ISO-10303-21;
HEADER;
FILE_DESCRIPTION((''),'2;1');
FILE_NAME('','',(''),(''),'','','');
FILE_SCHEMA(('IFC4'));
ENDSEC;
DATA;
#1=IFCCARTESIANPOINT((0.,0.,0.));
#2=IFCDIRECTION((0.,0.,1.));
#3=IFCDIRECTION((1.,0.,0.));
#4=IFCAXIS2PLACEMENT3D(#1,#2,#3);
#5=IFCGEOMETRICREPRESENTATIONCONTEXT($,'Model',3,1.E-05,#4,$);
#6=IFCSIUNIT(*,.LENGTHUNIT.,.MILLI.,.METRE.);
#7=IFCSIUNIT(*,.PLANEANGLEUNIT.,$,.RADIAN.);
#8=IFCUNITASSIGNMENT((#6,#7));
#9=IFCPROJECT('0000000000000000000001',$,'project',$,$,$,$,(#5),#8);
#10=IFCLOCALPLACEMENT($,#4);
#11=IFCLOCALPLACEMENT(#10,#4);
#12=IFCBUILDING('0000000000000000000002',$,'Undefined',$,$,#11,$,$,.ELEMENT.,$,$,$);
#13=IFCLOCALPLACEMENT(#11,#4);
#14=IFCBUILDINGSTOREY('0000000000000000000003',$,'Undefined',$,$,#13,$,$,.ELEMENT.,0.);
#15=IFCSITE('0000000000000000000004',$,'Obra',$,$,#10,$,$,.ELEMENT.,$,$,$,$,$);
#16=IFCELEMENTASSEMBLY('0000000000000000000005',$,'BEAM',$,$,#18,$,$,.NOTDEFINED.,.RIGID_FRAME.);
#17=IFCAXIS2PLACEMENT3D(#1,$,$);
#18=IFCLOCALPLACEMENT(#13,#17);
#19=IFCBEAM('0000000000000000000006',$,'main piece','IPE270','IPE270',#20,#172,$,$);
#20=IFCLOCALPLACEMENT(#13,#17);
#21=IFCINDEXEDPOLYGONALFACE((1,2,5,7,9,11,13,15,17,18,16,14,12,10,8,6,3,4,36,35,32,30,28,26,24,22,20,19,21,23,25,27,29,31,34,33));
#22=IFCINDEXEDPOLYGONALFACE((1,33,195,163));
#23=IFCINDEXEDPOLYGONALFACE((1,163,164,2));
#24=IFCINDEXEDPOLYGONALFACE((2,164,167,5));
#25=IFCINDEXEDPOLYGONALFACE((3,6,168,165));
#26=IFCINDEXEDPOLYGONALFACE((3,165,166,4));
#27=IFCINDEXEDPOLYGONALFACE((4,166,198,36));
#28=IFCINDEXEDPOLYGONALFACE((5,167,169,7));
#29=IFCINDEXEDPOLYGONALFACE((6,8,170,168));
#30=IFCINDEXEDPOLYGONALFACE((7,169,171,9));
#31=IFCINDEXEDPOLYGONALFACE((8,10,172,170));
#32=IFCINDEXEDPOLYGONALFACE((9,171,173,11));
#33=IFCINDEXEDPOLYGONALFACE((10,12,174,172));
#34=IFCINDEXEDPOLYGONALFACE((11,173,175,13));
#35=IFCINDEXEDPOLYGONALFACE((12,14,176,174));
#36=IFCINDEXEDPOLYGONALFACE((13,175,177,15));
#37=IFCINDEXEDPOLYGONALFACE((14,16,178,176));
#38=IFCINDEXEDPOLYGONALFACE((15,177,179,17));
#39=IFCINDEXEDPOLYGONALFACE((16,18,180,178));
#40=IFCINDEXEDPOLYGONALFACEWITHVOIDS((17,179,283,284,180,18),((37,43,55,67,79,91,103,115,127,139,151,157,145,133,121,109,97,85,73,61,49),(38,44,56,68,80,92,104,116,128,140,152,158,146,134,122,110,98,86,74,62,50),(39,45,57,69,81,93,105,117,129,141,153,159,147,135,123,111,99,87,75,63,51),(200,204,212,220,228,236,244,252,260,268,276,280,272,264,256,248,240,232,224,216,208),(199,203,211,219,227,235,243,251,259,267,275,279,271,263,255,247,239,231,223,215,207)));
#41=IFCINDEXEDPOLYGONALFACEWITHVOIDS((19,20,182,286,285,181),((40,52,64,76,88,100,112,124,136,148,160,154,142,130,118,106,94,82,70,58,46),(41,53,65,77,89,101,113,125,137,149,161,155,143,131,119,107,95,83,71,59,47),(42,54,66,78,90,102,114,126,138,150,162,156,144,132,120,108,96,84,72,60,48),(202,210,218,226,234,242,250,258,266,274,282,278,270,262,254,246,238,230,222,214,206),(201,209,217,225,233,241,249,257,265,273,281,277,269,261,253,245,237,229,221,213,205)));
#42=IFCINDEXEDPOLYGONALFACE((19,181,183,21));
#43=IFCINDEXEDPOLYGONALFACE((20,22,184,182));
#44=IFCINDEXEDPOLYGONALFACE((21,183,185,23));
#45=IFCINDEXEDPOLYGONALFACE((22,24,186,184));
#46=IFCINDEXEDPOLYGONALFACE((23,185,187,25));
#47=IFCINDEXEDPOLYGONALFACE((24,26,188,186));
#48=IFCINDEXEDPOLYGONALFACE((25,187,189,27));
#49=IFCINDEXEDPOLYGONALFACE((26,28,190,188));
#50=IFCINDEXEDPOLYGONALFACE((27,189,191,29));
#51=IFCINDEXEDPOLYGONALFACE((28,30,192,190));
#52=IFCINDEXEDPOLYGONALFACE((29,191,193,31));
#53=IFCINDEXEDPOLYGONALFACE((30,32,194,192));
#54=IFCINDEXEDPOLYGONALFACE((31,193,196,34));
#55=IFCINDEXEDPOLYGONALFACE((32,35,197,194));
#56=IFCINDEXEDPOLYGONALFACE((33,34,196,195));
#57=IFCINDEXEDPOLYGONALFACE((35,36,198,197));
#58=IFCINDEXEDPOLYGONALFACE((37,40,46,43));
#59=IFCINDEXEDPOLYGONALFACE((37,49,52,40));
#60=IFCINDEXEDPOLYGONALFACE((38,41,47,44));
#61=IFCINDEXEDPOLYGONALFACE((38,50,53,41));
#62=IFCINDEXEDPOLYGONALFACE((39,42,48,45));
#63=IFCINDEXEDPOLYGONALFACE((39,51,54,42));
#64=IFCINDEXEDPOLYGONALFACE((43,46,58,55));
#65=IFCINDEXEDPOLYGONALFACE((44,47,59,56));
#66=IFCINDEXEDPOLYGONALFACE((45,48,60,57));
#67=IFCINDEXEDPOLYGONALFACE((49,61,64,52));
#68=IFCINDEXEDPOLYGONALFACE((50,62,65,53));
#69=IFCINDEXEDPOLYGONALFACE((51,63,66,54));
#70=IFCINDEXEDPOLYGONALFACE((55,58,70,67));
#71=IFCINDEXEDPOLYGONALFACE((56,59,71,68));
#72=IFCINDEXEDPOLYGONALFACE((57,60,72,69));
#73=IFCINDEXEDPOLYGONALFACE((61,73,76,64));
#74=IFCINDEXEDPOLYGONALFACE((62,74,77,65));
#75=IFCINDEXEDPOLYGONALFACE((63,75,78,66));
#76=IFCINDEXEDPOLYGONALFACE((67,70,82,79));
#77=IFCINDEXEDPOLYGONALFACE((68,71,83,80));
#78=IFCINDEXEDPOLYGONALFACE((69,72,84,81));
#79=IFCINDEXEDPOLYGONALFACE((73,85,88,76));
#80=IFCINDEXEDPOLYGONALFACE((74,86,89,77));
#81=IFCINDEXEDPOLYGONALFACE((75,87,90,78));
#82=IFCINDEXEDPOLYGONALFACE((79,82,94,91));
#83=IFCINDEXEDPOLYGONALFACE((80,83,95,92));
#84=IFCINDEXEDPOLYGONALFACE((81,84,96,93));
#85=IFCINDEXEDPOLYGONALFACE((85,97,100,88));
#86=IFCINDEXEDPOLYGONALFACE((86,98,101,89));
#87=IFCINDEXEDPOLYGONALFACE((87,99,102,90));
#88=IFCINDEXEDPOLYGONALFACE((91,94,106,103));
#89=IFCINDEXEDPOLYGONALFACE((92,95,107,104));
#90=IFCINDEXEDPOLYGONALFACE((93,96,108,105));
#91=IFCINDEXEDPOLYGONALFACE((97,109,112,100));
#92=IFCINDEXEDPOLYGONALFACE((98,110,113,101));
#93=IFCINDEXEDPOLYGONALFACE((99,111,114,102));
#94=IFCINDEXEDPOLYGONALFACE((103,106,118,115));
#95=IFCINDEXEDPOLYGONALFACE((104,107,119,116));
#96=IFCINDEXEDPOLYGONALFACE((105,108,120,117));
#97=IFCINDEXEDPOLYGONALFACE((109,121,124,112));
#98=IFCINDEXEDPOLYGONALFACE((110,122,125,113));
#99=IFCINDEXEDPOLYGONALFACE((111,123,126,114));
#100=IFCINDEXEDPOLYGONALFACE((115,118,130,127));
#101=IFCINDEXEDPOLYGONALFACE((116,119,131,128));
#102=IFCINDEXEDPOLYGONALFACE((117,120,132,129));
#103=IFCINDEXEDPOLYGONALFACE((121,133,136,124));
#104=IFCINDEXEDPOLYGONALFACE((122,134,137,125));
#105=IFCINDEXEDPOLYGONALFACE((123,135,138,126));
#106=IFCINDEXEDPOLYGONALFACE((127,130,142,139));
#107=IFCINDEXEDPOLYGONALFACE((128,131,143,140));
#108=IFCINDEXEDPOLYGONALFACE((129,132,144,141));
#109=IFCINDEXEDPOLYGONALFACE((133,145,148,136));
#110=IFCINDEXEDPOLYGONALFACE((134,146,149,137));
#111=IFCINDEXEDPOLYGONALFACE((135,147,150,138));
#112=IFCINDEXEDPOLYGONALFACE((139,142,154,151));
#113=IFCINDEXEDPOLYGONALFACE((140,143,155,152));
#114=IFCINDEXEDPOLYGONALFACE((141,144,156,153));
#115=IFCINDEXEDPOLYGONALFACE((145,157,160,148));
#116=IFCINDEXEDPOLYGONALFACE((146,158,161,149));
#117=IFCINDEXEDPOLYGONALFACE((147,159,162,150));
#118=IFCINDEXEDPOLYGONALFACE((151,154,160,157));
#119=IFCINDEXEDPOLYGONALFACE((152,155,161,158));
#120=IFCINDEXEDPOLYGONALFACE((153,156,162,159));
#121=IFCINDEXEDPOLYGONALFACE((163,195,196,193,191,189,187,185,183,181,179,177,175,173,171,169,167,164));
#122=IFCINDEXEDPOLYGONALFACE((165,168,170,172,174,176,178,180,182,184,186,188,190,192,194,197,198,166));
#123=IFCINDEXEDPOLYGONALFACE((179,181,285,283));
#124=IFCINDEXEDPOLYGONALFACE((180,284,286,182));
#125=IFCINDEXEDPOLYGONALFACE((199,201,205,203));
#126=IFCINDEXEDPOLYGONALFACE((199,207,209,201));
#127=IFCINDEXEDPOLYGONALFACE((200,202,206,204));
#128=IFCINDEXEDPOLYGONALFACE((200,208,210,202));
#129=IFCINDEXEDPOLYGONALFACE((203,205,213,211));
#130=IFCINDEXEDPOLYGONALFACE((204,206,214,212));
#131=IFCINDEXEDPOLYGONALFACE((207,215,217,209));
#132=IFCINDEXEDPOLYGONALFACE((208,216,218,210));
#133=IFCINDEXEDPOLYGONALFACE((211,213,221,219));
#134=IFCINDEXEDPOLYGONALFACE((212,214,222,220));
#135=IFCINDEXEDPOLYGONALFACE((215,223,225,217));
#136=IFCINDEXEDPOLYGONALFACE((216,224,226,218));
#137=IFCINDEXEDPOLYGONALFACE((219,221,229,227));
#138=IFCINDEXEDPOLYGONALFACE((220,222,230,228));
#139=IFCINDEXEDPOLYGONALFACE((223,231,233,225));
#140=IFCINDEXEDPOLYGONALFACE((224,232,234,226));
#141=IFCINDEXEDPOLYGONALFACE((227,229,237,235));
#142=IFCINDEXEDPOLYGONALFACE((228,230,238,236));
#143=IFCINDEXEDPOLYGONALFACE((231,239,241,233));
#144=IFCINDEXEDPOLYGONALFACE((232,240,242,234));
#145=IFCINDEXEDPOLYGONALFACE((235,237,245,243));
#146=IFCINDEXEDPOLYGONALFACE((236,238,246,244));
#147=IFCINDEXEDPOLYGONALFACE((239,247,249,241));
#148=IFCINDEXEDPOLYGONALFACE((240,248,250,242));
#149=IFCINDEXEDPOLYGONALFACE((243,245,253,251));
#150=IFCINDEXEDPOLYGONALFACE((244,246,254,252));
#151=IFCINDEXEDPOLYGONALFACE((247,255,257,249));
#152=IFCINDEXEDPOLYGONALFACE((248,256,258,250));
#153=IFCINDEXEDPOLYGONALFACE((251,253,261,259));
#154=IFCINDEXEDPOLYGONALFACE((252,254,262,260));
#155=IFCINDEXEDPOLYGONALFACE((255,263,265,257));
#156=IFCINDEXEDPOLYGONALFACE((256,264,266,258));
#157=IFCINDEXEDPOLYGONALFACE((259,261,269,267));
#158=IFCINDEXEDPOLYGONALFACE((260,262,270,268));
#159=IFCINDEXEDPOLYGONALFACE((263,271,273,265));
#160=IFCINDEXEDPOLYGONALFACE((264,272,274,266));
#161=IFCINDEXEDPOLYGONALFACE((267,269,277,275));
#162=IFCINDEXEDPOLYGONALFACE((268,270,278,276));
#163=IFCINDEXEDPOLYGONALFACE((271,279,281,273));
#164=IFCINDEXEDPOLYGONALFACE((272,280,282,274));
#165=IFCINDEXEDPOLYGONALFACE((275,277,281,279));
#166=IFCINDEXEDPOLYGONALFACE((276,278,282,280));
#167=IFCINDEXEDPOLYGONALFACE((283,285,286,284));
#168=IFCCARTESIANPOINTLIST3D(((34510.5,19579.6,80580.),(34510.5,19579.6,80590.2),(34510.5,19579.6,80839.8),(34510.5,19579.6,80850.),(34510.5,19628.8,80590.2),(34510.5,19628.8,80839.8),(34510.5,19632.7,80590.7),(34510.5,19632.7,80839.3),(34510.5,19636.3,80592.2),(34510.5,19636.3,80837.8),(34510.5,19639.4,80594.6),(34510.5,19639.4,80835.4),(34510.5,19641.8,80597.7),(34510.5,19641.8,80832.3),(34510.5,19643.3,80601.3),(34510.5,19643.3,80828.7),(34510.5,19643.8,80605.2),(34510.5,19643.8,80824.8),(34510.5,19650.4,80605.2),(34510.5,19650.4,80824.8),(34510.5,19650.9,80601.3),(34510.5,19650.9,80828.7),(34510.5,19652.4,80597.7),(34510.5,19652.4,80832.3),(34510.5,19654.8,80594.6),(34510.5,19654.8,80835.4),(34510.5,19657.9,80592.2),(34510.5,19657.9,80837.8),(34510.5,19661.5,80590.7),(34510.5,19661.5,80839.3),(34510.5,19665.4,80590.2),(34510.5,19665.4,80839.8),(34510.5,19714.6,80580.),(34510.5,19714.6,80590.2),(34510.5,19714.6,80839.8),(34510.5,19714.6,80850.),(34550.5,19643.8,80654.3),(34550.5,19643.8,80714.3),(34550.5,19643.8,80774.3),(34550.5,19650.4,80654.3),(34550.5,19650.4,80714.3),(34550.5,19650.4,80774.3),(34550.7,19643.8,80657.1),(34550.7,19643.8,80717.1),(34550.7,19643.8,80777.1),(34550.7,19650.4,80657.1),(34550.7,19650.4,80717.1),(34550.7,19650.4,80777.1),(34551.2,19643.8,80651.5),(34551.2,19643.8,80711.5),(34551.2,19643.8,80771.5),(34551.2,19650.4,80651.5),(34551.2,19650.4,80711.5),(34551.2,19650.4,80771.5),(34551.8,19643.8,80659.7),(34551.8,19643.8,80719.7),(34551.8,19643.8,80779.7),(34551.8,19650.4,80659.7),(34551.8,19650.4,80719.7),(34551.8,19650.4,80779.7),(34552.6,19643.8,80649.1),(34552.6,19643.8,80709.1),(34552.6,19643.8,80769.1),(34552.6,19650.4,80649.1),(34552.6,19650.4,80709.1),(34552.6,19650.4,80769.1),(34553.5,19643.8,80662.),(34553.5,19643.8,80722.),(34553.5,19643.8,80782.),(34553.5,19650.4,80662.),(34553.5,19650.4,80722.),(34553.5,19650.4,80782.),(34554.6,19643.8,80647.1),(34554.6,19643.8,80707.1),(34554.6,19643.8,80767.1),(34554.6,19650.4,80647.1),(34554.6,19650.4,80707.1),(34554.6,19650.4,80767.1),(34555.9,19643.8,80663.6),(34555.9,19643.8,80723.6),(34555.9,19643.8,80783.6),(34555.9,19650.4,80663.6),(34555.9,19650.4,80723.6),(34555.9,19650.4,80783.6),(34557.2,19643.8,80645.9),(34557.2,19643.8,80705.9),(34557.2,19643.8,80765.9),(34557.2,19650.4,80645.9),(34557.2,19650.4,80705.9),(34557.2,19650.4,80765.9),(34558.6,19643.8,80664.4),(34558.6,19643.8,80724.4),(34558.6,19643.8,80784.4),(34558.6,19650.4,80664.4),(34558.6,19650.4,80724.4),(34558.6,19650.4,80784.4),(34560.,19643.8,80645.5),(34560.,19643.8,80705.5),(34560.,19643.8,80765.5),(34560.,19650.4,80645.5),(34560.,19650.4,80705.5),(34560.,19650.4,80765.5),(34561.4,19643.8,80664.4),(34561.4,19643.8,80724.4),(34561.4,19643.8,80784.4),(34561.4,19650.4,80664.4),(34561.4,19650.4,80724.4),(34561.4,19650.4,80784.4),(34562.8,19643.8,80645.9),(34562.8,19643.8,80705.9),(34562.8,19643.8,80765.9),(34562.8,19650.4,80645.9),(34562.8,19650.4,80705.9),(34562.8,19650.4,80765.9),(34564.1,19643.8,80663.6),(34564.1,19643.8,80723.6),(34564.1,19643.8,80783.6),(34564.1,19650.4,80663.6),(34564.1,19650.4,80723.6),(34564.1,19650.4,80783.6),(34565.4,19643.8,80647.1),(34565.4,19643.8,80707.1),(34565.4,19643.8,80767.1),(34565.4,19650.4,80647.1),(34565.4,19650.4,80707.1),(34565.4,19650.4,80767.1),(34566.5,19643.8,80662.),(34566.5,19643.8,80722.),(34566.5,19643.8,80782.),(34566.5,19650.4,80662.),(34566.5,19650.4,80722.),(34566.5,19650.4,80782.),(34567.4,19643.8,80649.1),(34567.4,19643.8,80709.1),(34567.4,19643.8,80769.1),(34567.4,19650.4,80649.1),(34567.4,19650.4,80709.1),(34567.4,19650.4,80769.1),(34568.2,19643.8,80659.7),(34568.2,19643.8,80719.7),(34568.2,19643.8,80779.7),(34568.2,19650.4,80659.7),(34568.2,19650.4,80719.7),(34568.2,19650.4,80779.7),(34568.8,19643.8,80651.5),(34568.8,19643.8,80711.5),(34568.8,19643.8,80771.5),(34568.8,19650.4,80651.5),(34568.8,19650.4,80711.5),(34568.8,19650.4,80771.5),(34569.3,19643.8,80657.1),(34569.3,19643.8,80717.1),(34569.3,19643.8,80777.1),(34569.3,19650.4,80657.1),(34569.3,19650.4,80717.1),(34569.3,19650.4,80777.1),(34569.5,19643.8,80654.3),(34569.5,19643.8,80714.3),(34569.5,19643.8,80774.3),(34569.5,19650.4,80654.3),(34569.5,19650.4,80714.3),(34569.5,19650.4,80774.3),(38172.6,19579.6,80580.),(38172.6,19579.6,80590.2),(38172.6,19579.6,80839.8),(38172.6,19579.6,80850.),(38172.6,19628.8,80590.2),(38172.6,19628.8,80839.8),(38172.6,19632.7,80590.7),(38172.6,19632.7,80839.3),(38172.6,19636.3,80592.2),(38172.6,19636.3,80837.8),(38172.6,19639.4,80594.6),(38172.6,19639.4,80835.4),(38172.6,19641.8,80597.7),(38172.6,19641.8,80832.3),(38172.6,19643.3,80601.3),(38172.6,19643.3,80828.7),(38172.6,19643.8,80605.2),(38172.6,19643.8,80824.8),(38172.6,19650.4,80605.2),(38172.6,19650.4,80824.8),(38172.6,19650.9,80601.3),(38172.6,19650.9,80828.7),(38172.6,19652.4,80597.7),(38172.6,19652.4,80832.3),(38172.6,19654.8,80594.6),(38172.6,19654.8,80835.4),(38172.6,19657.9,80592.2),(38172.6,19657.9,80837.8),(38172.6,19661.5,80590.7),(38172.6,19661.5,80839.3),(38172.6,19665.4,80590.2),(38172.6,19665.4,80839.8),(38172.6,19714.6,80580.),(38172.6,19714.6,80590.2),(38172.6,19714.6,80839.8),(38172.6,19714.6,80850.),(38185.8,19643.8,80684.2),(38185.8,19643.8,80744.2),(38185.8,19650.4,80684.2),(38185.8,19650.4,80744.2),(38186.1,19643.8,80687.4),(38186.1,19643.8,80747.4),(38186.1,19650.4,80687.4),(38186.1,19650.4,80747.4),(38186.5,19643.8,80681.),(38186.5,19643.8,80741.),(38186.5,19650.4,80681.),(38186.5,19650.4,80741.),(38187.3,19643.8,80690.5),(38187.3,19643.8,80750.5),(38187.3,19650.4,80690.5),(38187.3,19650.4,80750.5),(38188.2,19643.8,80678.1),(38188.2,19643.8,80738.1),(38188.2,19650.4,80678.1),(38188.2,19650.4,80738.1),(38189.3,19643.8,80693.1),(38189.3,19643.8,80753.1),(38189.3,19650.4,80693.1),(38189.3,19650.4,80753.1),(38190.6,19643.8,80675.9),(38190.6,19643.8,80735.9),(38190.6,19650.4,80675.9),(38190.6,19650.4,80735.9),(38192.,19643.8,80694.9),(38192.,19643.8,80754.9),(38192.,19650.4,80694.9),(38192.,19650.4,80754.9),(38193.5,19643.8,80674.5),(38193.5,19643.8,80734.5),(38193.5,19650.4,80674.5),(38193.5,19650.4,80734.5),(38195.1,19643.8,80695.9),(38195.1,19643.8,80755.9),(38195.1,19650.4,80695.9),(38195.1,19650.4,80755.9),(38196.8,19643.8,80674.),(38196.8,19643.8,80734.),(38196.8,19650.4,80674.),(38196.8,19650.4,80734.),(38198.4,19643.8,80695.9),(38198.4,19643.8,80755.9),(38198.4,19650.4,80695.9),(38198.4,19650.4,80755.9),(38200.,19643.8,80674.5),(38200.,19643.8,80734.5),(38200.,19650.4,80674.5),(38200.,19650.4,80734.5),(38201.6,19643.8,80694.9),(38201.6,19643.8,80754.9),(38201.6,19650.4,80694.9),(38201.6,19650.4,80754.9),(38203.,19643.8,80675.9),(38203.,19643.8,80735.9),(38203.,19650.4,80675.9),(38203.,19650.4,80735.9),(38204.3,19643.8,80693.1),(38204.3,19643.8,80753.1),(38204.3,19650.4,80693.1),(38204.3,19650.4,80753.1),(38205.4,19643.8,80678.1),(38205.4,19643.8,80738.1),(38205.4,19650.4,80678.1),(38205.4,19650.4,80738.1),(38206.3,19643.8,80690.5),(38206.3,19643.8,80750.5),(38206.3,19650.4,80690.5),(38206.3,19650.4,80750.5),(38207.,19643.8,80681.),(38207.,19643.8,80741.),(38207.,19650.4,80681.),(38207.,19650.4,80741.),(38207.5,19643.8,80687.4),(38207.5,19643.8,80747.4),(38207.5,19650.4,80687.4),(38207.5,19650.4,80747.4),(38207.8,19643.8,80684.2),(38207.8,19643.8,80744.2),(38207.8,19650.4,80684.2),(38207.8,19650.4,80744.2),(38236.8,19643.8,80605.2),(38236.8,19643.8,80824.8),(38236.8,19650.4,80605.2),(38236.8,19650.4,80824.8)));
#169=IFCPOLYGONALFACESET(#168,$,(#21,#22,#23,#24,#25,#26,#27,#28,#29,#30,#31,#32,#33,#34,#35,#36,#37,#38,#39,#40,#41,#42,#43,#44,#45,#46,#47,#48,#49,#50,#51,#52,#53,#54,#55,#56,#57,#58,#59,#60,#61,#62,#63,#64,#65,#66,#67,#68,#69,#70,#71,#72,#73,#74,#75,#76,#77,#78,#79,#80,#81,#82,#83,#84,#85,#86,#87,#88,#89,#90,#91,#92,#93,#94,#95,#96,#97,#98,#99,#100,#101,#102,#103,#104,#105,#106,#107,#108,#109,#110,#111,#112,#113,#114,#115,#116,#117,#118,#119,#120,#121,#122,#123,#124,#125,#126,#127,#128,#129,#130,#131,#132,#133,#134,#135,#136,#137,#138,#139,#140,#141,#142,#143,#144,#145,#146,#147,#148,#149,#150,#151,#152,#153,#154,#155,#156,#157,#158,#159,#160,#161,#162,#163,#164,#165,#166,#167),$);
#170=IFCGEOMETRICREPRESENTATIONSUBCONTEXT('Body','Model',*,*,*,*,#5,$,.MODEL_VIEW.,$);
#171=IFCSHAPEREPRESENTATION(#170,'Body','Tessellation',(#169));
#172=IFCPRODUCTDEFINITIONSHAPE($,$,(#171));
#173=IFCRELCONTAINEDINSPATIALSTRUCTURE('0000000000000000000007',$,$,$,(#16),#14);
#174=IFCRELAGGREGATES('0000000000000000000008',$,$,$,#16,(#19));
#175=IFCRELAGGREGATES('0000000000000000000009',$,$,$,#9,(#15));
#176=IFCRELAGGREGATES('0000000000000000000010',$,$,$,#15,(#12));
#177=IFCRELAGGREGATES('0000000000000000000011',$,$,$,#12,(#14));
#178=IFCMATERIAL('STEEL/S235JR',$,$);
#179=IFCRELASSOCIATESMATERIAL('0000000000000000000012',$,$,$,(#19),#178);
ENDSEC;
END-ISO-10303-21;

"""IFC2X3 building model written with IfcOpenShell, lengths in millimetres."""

from ifc_helpers import new_model, si_unit, frame, origin_with_axes, origin_2d_with_axis, place, context, subcontext, project, spatial, rectangle, circle, i_section, extrude, clip, halfspace, source, transform, mapped, material, element, aggregate, save


model = new_model("IFC2X3")

# Units and contexts
model_context = context("Model", 3, precision=1e-05, world=origin_with_axes())
body_context = subcontext(model_context, "Body", "Model", "MODEL_VIEW")
ifc_project = project(units=[si_unit("LENGTHUNIT", "METRE", prefix="MILLI"), si_unit("PLANEANGLEUNIT", "RADIAN")], contexts=[model_context])

# Site, building, storey
site_placement = place(None, origin_with_axes())
site = spatial("IfcSite", under=ifc_project, at=site_placement, Name="Obra", CompositionType="ELEMENT")
building_placement = place(site_placement, origin_with_axes())
building = spatial("IfcBuilding", under=site, at=building_placement, Name="Undefined", CompositionType="ELEMENT")
storey_placement = place(building_placement, origin_with_axes())
storey = spatial("IfcBuildingStorey", under=building, at=storey_placement, Name="Undefined", CompositionType="ELEMENT", Elevation=0.0)

# Shared definitions
ifc_material_1 = material(Name="STEEL/S235JR")
shared_shape_1 = source(origin_with_axes(), body_context, "Body", "SweptSolid", [
    extrude(circle(Radius=9.5, at=origin_2d_with_axis()), frame((0.0, -3.4, 0.0), z_axis=(0.0, 1.0, 0.0), x_axis=(1.0, 0.0, 0.0)), (0.0, 0.0, 1.0), 6.8),
])

# Element assembly, beam, openings
assembly_1_placement = place(storey_placement, origin_with_axes())
assembly_1 = element("IfcElementAssembly", 1, at=assembly_1_placement, inside=storey, Name="BEAM", AssemblyPlace="NOTDEFINED", PredefinedType="RIGID_FRAME")
beam_1_placement = place(assembly_1_placement, frame((34272.7, 19647.1, 80715.0), z_axis=(0.0, 0.0, 1.0), x_axis=(1.0, 0.0, 0.0)))
beam_1 = element("IfcBeam", 2, at=beam_1_placement, material=ifc_material_1, Name="main piece", Description="IPE270", ObjectType="IPE270", context=body_context, shape_type="Clipping", body=[
    clip(clip(extrude(i_section(OverallWidth=135.0, OverallDepth=270.0, WebThickness=6.6, FlangeThickness=10.2, FilletRadius=15.0, at=origin_2d_with_axis()), frame((3964.1, 0.0, 0.0), z_axis=(-1.0, 0.0, 0.0), x_axis=(0.0, -1.0, 0.0)), (0.0, 0.0, 1.0), 3964.1), halfspace(frame((237.8, 60.0, -120.0), z_axis=(-1.0, -0.000019, 0.0), x_axis=(0.0, 0.0, 1.0)), False)), halfspace(frame((3964.1, 0.0, -235.0), z_axis=(-1.0, 0.0, 0.0), x_axis=(0.0, 1.0, 0.0)), True)),
])
opening_1_placement = place(assembly_1_placement, frame((34272.7, 19647.1, 80715.0), z_axis=(0.0, 0.0, 1.0), x_axis=(1.0, 0.0, 0.0)))
element("IfcOpeningElement", 3, at=opening_1_placement, cuts=beam_1, ObjectType="Recess", context=body_context, shape_type="SweptSolid", body=[
    extrude(rectangle(XDim=26.2, YDim=76.2, at=origin_2d_with_axis()), frame((3938.0, 68.5, -122.9), z_axis=(0.0, -1.0, 0.0), x_axis=(0.0, 0.0, -1.0)), (0.0, 0.0, 1.0), 137.0),
])
opening_2_placement = place(assembly_1_placement, frame((34272.7, 19647.1, 80715.0), z_axis=(0.0, 0.0, 1.0), x_axis=(1.0, 0.0, 0.0)))
element("IfcOpeningElement", 4, at=opening_2_placement, cuts=beam_1, ObjectType="Recess", context=body_context, shape_type="SweptSolid", body=[
    extrude(rectangle(XDim=26.2, YDim=76.2, at=origin_2d_with_axis()), frame((3938.0, 68.5, 122.9), z_axis=(0.0, -1.0, 0.0), x_axis=(0.0, 0.0, -1.0)), (0.0, 0.0, 1.0), 137.0),
])
shared_shape_2 = source(origin_with_axes(), body_context, "Body", "SweptSolid", [
    extrude(circle(Radius=11.0, at=origin_2d_with_axis()), frame((0.0, -3.4, 0.0), z_axis=(0.0, 1.0, 0.0), x_axis=(1.0, 0.0, 0.0)), (0.0, 0.0, 1.0), 6.8),
])
opening_3_placement = place(assembly_1_placement, frame((38236.8, 19647.1, 80850.0), z_axis=(-1.0, 0.0, 0.0), x_axis=(0.0, 0.0, -1.0)))
element("IfcOpeningElement", 5, at=opening_3_placement, cuts=beam_1, ObjectType="Opening", context=body_context, shape_type="MappedRepresentation", body=[
    mapped(shared_shape_2, transform((105.0, 0.0, 40.0))),
    mapped(shared_shape_2, transform((165.0, 0.0, 40.0))),
])
opening_4_placement = place(assembly_1_placement, frame((34510.0, 19647.1, 80835.0), z_axis=(1.0, 0.0, 0.0), x_axis=(0.0, 0.0, -1.0)))
element("IfcOpeningElement", 6, at=opening_4_placement, cuts=beam_1, ObjectType="Opening", context=body_context, shape_type="MappedRepresentation", body=[
    mapped(shared_shape_1, transform((60.0, 0.0, 50.0))),
    mapped(shared_shape_1, transform((120.0, 0.0, 50.0))),
    mapped(shared_shape_1, transform((180.0, 0.0, 50.0))),
])

aggregate(assembly_1, [beam_1])

save(model, "model.ifc")
